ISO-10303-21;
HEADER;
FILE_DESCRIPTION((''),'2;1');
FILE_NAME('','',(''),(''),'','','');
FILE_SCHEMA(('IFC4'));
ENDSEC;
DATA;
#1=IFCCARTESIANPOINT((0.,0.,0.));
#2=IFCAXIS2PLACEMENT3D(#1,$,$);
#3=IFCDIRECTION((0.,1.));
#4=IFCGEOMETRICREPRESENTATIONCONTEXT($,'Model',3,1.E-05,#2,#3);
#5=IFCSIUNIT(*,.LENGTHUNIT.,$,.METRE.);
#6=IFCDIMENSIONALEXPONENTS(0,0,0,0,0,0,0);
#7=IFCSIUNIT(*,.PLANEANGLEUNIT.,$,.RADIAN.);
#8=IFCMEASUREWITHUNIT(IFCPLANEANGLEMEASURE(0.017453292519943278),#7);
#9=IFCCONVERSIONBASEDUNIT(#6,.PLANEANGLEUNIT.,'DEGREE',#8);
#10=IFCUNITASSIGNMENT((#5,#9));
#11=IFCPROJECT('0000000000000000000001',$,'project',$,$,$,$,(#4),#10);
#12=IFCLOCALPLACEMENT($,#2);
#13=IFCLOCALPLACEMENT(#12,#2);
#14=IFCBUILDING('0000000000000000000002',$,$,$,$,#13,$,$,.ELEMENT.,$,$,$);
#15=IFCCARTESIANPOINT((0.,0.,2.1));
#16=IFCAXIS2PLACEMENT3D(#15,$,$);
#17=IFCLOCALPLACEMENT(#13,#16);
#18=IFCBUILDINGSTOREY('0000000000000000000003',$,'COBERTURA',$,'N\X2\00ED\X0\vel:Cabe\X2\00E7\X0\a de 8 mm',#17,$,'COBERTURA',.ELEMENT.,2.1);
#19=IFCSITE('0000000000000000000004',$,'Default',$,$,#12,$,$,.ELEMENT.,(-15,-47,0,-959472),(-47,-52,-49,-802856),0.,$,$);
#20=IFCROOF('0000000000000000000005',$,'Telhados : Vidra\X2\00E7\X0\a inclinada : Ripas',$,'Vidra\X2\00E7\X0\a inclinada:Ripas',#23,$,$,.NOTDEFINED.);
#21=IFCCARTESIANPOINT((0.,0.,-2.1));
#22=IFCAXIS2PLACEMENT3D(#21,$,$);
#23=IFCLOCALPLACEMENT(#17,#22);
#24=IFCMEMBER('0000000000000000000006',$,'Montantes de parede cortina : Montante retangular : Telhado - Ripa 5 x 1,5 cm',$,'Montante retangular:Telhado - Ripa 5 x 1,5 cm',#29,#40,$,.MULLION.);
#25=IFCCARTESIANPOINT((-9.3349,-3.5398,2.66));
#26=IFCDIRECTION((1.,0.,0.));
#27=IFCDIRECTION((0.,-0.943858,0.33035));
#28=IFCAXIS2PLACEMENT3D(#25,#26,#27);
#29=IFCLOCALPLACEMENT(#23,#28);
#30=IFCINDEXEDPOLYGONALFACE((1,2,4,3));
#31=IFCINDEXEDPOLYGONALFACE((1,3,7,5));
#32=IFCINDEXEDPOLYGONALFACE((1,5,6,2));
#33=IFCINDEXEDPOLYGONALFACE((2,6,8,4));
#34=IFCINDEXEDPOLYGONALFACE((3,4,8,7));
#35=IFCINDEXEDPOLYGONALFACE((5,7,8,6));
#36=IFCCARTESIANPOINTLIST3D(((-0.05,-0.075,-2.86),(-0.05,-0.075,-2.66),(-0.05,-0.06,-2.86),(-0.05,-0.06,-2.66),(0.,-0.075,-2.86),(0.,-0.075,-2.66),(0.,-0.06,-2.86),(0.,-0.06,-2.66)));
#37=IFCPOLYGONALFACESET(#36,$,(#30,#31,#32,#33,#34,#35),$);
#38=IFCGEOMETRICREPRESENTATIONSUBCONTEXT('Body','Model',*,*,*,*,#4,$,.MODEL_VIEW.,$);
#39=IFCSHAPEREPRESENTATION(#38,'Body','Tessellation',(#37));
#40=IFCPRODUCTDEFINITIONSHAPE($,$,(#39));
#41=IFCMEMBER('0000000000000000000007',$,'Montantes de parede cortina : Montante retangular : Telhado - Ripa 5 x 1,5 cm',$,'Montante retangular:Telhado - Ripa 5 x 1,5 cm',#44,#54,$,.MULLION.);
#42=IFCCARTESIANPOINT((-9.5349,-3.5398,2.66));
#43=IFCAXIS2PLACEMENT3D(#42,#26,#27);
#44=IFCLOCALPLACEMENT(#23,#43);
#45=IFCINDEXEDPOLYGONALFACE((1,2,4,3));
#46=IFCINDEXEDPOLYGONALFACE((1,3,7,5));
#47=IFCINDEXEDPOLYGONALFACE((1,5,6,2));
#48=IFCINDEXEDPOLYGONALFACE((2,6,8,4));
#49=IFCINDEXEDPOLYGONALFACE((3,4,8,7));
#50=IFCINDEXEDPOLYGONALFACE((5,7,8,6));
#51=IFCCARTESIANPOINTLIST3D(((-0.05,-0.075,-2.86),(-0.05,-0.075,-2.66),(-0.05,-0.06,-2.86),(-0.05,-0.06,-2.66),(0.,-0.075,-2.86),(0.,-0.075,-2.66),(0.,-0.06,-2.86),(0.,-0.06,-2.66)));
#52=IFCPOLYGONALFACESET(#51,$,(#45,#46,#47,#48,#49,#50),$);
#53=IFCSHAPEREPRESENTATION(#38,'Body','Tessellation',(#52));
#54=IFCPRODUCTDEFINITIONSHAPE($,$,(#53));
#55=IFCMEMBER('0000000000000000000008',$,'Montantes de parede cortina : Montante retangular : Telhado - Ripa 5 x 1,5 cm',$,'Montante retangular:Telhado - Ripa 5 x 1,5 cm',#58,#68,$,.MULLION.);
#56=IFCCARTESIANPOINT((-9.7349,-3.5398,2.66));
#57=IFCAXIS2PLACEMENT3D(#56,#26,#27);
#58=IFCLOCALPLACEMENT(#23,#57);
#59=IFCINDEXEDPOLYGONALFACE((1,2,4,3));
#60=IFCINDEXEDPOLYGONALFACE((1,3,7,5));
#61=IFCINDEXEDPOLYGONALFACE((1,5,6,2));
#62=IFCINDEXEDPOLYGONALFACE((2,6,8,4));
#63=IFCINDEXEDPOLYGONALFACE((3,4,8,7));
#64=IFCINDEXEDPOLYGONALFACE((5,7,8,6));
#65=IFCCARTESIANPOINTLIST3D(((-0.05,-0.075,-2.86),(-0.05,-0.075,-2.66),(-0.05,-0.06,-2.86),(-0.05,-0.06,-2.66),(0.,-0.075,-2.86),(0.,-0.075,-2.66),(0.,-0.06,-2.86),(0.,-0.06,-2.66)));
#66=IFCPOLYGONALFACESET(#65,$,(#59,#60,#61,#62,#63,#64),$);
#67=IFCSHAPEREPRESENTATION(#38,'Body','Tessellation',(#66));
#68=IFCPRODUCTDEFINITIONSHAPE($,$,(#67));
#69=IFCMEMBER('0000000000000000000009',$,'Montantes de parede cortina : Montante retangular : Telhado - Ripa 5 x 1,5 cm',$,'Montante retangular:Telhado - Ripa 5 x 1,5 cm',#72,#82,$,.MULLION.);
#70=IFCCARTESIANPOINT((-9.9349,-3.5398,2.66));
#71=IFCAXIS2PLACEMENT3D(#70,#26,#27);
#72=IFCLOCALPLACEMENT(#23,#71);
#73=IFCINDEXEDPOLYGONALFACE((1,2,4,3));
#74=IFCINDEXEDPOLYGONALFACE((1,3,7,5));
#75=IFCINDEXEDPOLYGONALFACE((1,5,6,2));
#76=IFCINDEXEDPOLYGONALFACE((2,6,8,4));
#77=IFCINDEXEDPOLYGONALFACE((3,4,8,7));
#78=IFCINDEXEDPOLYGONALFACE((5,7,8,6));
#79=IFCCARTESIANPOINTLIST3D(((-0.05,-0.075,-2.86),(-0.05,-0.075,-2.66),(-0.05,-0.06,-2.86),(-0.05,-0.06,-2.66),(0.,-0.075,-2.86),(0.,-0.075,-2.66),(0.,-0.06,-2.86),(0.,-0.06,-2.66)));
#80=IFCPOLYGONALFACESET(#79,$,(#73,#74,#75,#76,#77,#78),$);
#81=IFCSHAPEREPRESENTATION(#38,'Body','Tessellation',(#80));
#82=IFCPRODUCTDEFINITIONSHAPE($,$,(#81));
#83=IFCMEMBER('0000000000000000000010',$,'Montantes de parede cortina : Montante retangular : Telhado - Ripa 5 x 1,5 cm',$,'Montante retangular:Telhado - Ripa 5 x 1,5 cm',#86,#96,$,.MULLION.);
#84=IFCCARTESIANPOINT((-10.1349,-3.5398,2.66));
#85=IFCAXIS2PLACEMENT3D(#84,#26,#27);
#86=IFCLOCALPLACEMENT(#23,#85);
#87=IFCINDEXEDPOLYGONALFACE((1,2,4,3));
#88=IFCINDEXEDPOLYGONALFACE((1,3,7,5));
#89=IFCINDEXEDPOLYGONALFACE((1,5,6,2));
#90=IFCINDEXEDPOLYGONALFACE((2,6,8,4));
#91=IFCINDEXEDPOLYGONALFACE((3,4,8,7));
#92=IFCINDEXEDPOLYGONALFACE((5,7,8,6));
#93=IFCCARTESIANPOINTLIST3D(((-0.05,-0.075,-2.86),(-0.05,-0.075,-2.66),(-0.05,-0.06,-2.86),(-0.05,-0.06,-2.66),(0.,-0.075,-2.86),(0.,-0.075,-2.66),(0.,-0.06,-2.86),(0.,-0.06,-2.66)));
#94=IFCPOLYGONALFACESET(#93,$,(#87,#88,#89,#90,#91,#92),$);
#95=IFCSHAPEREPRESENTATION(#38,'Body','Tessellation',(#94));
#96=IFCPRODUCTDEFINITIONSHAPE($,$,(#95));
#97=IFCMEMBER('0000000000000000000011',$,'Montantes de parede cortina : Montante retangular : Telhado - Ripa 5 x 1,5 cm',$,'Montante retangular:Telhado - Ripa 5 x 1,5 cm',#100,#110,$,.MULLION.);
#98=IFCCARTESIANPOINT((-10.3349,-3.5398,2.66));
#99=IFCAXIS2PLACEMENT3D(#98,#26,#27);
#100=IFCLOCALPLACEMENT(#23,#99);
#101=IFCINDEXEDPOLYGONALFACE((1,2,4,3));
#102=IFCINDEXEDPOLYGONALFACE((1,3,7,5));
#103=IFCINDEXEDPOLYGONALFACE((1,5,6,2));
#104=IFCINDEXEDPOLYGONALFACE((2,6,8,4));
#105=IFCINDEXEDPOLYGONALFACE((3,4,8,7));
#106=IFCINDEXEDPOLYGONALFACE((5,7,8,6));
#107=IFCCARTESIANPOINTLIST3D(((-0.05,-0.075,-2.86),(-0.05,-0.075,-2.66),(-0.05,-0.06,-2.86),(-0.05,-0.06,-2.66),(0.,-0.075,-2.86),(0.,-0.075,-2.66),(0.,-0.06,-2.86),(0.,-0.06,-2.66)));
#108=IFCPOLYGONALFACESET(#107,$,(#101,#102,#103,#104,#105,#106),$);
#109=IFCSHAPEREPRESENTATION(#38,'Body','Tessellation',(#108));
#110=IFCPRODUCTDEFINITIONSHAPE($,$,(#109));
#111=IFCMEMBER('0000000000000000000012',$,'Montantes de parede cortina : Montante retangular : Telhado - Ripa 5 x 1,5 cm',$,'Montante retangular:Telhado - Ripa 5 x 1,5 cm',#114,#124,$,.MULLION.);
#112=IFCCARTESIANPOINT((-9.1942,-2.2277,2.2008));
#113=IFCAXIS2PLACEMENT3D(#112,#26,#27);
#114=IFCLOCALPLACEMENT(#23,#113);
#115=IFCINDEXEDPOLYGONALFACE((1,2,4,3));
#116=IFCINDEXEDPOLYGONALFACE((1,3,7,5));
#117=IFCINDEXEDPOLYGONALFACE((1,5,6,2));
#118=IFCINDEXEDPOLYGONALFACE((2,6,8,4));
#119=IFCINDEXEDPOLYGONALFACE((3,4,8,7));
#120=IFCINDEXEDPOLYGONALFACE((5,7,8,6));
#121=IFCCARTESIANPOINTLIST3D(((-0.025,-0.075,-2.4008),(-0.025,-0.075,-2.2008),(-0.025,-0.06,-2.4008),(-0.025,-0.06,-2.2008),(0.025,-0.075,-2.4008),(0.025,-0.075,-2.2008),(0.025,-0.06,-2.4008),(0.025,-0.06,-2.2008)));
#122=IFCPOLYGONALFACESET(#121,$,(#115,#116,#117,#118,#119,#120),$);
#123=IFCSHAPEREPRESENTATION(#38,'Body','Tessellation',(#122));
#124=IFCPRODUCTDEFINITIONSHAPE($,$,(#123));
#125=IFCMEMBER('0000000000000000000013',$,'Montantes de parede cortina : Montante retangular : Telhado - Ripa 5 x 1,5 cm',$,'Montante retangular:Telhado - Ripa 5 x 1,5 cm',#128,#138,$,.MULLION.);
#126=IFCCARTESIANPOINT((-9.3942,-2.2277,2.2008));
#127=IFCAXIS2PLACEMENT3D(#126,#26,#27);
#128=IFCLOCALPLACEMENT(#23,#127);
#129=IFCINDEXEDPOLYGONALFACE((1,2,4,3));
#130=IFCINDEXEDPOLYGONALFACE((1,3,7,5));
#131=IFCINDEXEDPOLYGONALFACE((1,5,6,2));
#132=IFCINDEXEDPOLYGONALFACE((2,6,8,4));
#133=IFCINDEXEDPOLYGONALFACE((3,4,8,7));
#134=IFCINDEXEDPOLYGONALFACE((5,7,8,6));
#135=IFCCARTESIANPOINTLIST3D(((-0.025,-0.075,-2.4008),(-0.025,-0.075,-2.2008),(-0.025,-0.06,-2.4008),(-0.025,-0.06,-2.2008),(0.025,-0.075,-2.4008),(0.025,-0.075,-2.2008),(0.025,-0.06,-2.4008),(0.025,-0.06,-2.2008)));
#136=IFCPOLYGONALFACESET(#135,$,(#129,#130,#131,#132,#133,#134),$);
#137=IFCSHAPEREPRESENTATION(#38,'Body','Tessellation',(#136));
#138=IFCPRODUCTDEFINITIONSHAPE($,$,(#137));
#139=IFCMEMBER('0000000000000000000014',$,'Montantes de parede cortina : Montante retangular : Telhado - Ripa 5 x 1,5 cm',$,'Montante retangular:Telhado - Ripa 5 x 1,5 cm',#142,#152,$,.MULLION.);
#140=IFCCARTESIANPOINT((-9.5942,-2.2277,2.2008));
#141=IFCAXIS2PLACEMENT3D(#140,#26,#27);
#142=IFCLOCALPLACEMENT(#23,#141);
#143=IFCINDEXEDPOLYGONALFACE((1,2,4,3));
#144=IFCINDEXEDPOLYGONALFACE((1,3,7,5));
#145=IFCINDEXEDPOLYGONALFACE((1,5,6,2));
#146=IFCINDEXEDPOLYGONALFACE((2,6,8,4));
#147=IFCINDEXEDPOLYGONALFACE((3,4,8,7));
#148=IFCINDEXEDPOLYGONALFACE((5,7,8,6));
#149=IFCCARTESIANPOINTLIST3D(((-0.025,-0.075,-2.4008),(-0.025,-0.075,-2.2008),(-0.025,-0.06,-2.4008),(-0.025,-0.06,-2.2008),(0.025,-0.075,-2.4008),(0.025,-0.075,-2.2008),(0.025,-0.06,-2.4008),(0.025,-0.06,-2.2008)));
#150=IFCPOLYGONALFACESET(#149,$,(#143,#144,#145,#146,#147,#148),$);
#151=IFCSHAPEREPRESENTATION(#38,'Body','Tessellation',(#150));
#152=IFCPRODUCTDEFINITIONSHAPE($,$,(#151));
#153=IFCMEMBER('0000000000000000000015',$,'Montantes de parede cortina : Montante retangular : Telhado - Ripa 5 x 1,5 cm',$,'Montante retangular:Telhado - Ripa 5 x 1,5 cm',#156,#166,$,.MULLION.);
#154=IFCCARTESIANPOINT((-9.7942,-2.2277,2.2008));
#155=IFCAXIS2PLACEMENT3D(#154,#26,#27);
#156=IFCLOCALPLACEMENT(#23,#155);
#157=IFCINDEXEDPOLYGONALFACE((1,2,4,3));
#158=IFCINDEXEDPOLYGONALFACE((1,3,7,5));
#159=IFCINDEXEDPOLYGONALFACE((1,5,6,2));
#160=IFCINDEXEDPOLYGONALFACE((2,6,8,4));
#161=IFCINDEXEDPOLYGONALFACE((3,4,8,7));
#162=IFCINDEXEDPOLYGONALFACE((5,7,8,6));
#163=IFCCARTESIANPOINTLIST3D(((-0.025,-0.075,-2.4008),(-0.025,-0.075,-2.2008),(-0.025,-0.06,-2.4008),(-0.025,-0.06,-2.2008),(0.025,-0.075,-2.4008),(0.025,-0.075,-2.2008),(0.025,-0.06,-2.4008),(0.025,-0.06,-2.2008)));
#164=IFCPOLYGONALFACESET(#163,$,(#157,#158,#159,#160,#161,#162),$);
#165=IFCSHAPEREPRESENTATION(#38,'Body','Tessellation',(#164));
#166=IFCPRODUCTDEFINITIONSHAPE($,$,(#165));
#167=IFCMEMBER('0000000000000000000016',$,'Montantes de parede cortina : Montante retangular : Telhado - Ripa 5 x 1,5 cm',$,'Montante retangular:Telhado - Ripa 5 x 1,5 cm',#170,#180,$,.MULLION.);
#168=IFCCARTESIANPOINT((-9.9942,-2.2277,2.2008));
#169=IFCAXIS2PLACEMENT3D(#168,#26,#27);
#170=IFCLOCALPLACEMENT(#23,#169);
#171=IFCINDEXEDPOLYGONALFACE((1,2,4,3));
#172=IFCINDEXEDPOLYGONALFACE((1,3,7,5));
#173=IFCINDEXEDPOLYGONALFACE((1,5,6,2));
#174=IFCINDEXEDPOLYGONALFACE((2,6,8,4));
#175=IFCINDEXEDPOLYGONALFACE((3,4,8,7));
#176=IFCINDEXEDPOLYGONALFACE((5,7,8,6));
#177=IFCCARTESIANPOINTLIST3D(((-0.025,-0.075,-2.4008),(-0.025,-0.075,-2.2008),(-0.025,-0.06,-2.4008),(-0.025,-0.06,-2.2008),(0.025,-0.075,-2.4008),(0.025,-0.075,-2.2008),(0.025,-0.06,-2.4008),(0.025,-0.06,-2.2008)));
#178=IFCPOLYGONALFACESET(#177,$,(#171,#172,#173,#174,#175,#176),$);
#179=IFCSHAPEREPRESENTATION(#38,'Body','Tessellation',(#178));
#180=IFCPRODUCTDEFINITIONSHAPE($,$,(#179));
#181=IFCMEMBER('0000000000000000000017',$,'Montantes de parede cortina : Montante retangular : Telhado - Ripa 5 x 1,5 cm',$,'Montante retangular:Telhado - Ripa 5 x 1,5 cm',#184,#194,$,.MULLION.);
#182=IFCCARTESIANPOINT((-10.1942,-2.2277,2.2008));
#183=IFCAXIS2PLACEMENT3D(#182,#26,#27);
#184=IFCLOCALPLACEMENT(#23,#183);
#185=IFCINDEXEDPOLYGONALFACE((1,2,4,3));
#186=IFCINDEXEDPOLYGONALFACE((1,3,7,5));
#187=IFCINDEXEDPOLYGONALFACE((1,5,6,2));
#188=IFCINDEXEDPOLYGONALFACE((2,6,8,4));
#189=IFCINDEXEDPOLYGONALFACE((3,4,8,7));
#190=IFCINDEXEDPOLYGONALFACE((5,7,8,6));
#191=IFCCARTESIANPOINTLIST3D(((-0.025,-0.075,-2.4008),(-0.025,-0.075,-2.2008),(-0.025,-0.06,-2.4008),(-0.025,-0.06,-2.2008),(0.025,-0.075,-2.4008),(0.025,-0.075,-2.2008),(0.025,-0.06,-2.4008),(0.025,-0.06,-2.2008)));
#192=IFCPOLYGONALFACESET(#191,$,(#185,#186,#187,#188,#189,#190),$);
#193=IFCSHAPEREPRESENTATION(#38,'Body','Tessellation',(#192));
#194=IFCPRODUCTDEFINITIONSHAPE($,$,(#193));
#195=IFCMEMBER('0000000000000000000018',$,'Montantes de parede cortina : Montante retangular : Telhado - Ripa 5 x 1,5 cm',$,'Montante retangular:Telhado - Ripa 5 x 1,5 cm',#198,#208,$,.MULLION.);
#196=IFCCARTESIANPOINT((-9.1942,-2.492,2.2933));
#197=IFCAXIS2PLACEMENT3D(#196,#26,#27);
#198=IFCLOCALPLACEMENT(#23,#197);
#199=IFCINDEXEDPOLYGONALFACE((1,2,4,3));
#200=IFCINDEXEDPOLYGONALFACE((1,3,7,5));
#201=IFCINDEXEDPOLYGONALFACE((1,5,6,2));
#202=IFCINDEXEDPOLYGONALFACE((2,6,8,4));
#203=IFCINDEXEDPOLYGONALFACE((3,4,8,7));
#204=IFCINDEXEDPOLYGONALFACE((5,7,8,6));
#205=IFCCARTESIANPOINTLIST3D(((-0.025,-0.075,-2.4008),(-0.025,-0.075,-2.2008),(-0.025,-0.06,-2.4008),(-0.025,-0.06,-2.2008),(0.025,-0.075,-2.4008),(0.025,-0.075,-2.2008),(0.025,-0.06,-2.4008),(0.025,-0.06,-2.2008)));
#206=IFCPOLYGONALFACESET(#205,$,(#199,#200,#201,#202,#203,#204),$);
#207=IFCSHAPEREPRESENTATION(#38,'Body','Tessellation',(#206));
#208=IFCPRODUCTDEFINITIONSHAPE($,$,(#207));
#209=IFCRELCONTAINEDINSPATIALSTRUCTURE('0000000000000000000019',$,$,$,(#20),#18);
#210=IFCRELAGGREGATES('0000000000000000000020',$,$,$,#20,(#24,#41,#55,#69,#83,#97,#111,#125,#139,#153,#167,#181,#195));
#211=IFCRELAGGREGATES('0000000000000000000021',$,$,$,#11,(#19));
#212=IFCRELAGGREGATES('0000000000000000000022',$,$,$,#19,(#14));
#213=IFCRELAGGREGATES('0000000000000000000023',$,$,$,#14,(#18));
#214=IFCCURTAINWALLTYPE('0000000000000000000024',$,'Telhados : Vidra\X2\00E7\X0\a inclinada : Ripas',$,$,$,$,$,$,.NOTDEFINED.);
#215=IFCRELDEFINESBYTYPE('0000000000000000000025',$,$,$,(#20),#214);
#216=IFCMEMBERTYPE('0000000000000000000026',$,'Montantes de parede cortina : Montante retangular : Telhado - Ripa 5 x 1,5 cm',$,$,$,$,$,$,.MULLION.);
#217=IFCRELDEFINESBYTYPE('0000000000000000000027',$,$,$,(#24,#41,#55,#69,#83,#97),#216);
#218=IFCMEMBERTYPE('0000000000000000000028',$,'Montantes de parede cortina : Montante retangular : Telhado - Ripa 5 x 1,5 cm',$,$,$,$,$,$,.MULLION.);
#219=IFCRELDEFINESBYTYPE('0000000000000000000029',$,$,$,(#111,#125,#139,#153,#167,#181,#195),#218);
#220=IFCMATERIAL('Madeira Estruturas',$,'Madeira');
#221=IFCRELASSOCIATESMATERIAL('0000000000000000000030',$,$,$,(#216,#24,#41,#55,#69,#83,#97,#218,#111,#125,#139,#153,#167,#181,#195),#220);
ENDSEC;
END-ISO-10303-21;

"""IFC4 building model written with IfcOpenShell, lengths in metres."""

from ifc_helpers import new_model, entity, si_unit, converted_unit, direction, frame, origin, place, context, subcontext, project, spatial, indexed_curve, outline, extrude, source, transform, mapped, material, type_object, type_shapes, element, aggregate, save


model = new_model("IFC4")

# Units and contexts
model_context = context("Model", 3, precision=1e-05, world=origin(), true_north=direction((0.0, 1.0)))
body_context = subcontext(model_context, "Body", "Model", "MODEL_VIEW")
ifc_project = project(units=[si_unit("LENGTHUNIT", "METRE"), converted_unit("PLANEANGLEUNIT", "DEGREE", entity("IfcPlaneAngleMeasure", 0.017453292519943278), si_unit("PLANEANGLEUNIT", "RADIAN"), dimensions=[0, 0, 0, 0, 0, 0, 0])], contexts=[model_context])

# Site, building, storey
site_placement = place(None, origin())
site = spatial("IfcSite", under=ifc_project, at=site_placement, Name="Default", CompositionType="ELEMENT", RefLatitude=(-15, -47, 0, -959472), RefLongitude=(-47, -52, -49, -802856), RefElevation=0.0)
building_placement = place(site_placement, origin())
building = spatial("IfcBuilding", under=site, at=building_placement, CompositionType="ELEMENT")
storey_placement = place(building_placement, frame((0.0, 0.0, 2.1)))
storey = spatial("IfcBuildingStorey", under=building, at=storey_placement, Name="COBERTURA", ObjectType="Nível:Cabeça de 8 mm", LongName="COBERTURA", CompositionType="ELEMENT", Elevation=2.1)

# Roof, members
curtain_wall_type_1 = type_object("IfcCurtainWallType", Name="Telhados : Vidraça inclinada : Ripas", PredefinedType="NOTDEFINED")
roof_1_placement = place(storey_placement, frame((0.0, 0.0, -2.1)))
roof_1 = element("IfcRoof", 1, at=roof_1_placement, inside=storey, type_object=curtain_wall_type_1, Name="Telhados : Vidraça inclinada : Ripas", ObjectType="Vidraça inclinada:Ripas", PredefinedType="NOTDEFINED")
ifc_material_1 = material(Name="Madeira Estruturas", Category="Madeira")
member_type_1 = type_object("IfcMemberType", Name="Montantes de parede cortina : Montante retangular : Telhado - Ripa 5 x 1,5 cm", PredefinedType="MULLION", material=ifc_material_1)
shared_shape_1 = source(origin(), body_context, "Body", "SweptSolid", [
    extrude(outline(indexed_curve([(-0.025, -0.0075), (0.025, -0.0075), (0.025, 0.0075), (-0.025, 0.0075), (-0.025, -0.0075)], self_intersect=False)), frame((-0.025, -0.0675, -2.86), z_axis=(0.0, 0.0, 1.0), x_axis=(-1.0, 0.0, 0.0)), (0.0, 0.0, 1.0), 0.2),
])
type_shapes(member_type_1, [shared_shape_1])
member_1_placement = place(roof_1_placement, frame((-9.3349, -3.5398, 2.66), z_axis=(1.0, 0.0, 0.0), x_axis=(0.0, -0.943858, 0.33035)))
member_1 = element("IfcMember", 2, at=member_1_placement, type_object=member_type_1, material=ifc_material_1, Name="Montantes de parede cortina : Montante retangular : Telhado - Ripa 5 x 1,5 cm", ObjectType="Montante retangular:Telhado - Ripa 5 x 1,5 cm", PredefinedType="MULLION", context=body_context, shape_type="MappedRepresentation", body=[
    mapped(shared_shape_1, transform((0.0, 0.0, 0.0), scale=1.0)),
])
member_2_placement = place(roof_1_placement, frame((-9.5349, -3.5398, 2.66), z_axis=(1.0, 0.0, 0.0), x_axis=(0.0, -0.943858, 0.33035)))
member_2 = element("IfcMember", 3, at=member_2_placement, type_object=member_type_1, material=ifc_material_1, Name="Montantes de parede cortina : Montante retangular : Telhado - Ripa 5 x 1,5 cm", ObjectType="Montante retangular:Telhado - Ripa 5 x 1,5 cm", PredefinedType="MULLION", context=body_context, shape_type="MappedRepresentation", body=[
    mapped(shared_shape_1, transform((0.0, 0.0, 0.0), scale=1.0)),
])
member_3_placement = place(roof_1_placement, frame((-9.7349, -3.5398, 2.66), z_axis=(1.0, 0.0, 0.0), x_axis=(0.0, -0.943858, 0.33035)))
member_3 = element("IfcMember", 4, at=member_3_placement, type_object=member_type_1, material=ifc_material_1, Name="Montantes de parede cortina : Montante retangular : Telhado - Ripa 5 x 1,5 cm", ObjectType="Montante retangular:Telhado - Ripa 5 x 1,5 cm", PredefinedType="MULLION", context=body_context, shape_type="MappedRepresentation", body=[
    mapped(shared_shape_1, transform((0.0, 0.0, 0.0), scale=1.0)),
])
member_4_placement = place(roof_1_placement, frame((-9.9349, -3.5398, 2.66), z_axis=(1.0, 0.0, 0.0), x_axis=(0.0, -0.943858, 0.33035)))
member_4 = element("IfcMember", 5, at=member_4_placement, type_object=member_type_1, material=ifc_material_1, Name="Montantes de parede cortina : Montante retangular : Telhado - Ripa 5 x 1,5 cm", ObjectType="Montante retangular:Telhado - Ripa 5 x 1,5 cm", PredefinedType="MULLION", context=body_context, shape_type="MappedRepresentation", body=[
    mapped(shared_shape_1, transform((0.0, 0.0, 0.0), scale=1.0)),
])
member_5_placement = place(roof_1_placement, frame((-10.1349, -3.5398, 2.66), z_axis=(1.0, 0.0, 0.0), x_axis=(0.0, -0.943858, 0.33035)))
member_5 = element("IfcMember", 6, at=member_5_placement, type_object=member_type_1, material=ifc_material_1, Name="Montantes de parede cortina : Montante retangular : Telhado - Ripa 5 x 1,5 cm", ObjectType="Montante retangular:Telhado - Ripa 5 x 1,5 cm", PredefinedType="MULLION", context=body_context, shape_type="MappedRepresentation", body=[
    mapped(shared_shape_1, transform((0.0, 0.0, 0.0), scale=1.0)),
])
member_6_placement = place(roof_1_placement, frame((-10.3349, -3.5398, 2.66), z_axis=(1.0, 0.0, 0.0), x_axis=(0.0, -0.943858, 0.33035)))
member_6 = element("IfcMember", 7, at=member_6_placement, type_object=member_type_1, material=ifc_material_1, Name="Montantes de parede cortina : Montante retangular : Telhado - Ripa 5 x 1,5 cm", ObjectType="Montante retangular:Telhado - Ripa 5 x 1,5 cm", PredefinedType="MULLION", context=body_context, shape_type="MappedRepresentation", body=[
    mapped(shared_shape_1, transform((0.0, 0.0, 0.0), scale=1.0)),
])
member_type_2 = type_object("IfcMemberType", Name="Montantes de parede cortina : Montante retangular : Telhado - Ripa 5 x 1,5 cm", PredefinedType="MULLION", material=ifc_material_1)
shared_shape_2 = source(origin(), body_context, "Body", "SweptSolid", [
    extrude(outline(indexed_curve([(-0.025, -0.0075), (0.025, -0.0075), (0.025, 0.0075), (-0.025, 0.0075), (-0.025, -0.0075)], self_intersect=False)), frame((0.0, -0.0675, -2.4008), z_axis=(0.0, 0.0, 1.0), x_axis=(-1.0, 0.0, 0.0)), (0.0, 0.0, 1.0), 0.2),
])
type_shapes(member_type_2, [shared_shape_2])
member_7_placement = place(roof_1_placement, frame((-9.1942, -2.2277, 2.2008), z_axis=(1.0, 0.0, 0.0), x_axis=(0.0, -0.943858, 0.33035)))
member_7 = element("IfcMember", 8, at=member_7_placement, type_object=member_type_2, material=ifc_material_1, Name="Montantes de parede cortina : Montante retangular : Telhado - Ripa 5 x 1,5 cm", ObjectType="Montante retangular:Telhado - Ripa 5 x 1,5 cm", PredefinedType="MULLION", context=body_context, shape_type="MappedRepresentation", body=[
    mapped(shared_shape_2, transform((0.0, 0.0, 0.0), scale=1.0)),
])
member_8_placement = place(roof_1_placement, frame((-9.3942, -2.2277, 2.2008), z_axis=(1.0, 0.0, 0.0), x_axis=(0.0, -0.943858, 0.33035)))
member_8 = element("IfcMember", 9, at=member_8_placement, type_object=member_type_2, material=ifc_material_1, Name="Montantes de parede cortina : Montante retangular : Telhado - Ripa 5 x 1,5 cm", ObjectType="Montante retangular:Telhado - Ripa 5 x 1,5 cm", PredefinedType="MULLION", context=body_context, shape_type="MappedRepresentation", body=[
    mapped(shared_shape_2, transform((0.0, 0.0, 0.0), scale=1.0)),
])
member_9_placement = place(roof_1_placement, frame((-9.5942, -2.2277, 2.2008), z_axis=(1.0, 0.0, 0.0), x_axis=(0.0, -0.943858, 0.33035)))
member_9 = element("IfcMember", 10, at=member_9_placement, type_object=member_type_2, material=ifc_material_1, Name="Montantes de parede cortina : Montante retangular : Telhado - Ripa 5 x 1,5 cm", ObjectType="Montante retangular:Telhado - Ripa 5 x 1,5 cm", PredefinedType="MULLION", context=body_context, shape_type="MappedRepresentation", body=[
    mapped(shared_shape_2, transform((0.0, 0.0, 0.0), scale=1.0)),
])
member_10_placement = place(roof_1_placement, frame((-9.7942, -2.2277, 2.2008), z_axis=(1.0, 0.0, 0.0), x_axis=(0.0, -0.943858, 0.33035)))
member_10 = element("IfcMember", 11, at=member_10_placement, type_object=member_type_2, material=ifc_material_1, Name="Montantes de parede cortina : Montante retangular : Telhado - Ripa 5 x 1,5 cm", ObjectType="Montante retangular:Telhado - Ripa 5 x 1,5 cm", PredefinedType="MULLION", context=body_context, shape_type="MappedRepresentation", body=[
    mapped(shared_shape_2, transform((0.0, 0.0, 0.0), scale=1.0)),
])
member_11_placement = place(roof_1_placement, frame((-9.9942, -2.2277, 2.2008), z_axis=(1.0, 0.0, 0.0), x_axis=(0.0, -0.943858, 0.33035)))
member_11 = element("IfcMember", 12, at=member_11_placement, type_object=member_type_2, material=ifc_material_1, Name="Montantes de parede cortina : Montante retangular : Telhado - Ripa 5 x 1,5 cm", ObjectType="Montante retangular:Telhado - Ripa 5 x 1,5 cm", PredefinedType="MULLION", context=body_context, shape_type="MappedRepresentation", body=[
    mapped(shared_shape_2, transform((0.0, 0.0, 0.0), scale=1.0)),
])
member_12_placement = place(roof_1_placement, frame((-10.1942, -2.2277, 2.2008), z_axis=(1.0, 0.0, 0.0), x_axis=(0.0, -0.943858, 0.33035)))
member_12 = element("IfcMember", 13, at=member_12_placement, type_object=member_type_2, material=ifc_material_1, Name="Montantes de parede cortina : Montante retangular : Telhado - Ripa 5 x 1,5 cm", ObjectType="Montante retangular:Telhado - Ripa 5 x 1,5 cm", PredefinedType="MULLION", context=body_context, shape_type="MappedRepresentation", body=[
    mapped(shared_shape_2, transform((0.0, 0.0, 0.0), scale=1.0)),
])
member_13_placement = place(roof_1_placement, frame((-9.1942, -2.492, 2.2933), z_axis=(1.0, 0.0, 0.0), x_axis=(0.0, -0.943858, 0.33035)))
member_13 = element("IfcMember", 14, at=member_13_placement, type_object=member_type_2, material=ifc_material_1, Name="Montantes de parede cortina : Montante retangular : Telhado - Ripa 5 x 1,5 cm", ObjectType="Montante retangular:Telhado - Ripa 5 x 1,5 cm", PredefinedType="MULLION", context=body_context, shape_type="MappedRepresentation", body=[
    mapped(shared_shape_2, transform((0.0, 0.0, 0.0), scale=1.0)),
])
aggregate(roof_1, [member_1, member_2, member_3, member_4, member_5, member_6, member_7, member_8, member_9, member_10, member_11, member_12, member_13])

save(model, "model.ifc")
